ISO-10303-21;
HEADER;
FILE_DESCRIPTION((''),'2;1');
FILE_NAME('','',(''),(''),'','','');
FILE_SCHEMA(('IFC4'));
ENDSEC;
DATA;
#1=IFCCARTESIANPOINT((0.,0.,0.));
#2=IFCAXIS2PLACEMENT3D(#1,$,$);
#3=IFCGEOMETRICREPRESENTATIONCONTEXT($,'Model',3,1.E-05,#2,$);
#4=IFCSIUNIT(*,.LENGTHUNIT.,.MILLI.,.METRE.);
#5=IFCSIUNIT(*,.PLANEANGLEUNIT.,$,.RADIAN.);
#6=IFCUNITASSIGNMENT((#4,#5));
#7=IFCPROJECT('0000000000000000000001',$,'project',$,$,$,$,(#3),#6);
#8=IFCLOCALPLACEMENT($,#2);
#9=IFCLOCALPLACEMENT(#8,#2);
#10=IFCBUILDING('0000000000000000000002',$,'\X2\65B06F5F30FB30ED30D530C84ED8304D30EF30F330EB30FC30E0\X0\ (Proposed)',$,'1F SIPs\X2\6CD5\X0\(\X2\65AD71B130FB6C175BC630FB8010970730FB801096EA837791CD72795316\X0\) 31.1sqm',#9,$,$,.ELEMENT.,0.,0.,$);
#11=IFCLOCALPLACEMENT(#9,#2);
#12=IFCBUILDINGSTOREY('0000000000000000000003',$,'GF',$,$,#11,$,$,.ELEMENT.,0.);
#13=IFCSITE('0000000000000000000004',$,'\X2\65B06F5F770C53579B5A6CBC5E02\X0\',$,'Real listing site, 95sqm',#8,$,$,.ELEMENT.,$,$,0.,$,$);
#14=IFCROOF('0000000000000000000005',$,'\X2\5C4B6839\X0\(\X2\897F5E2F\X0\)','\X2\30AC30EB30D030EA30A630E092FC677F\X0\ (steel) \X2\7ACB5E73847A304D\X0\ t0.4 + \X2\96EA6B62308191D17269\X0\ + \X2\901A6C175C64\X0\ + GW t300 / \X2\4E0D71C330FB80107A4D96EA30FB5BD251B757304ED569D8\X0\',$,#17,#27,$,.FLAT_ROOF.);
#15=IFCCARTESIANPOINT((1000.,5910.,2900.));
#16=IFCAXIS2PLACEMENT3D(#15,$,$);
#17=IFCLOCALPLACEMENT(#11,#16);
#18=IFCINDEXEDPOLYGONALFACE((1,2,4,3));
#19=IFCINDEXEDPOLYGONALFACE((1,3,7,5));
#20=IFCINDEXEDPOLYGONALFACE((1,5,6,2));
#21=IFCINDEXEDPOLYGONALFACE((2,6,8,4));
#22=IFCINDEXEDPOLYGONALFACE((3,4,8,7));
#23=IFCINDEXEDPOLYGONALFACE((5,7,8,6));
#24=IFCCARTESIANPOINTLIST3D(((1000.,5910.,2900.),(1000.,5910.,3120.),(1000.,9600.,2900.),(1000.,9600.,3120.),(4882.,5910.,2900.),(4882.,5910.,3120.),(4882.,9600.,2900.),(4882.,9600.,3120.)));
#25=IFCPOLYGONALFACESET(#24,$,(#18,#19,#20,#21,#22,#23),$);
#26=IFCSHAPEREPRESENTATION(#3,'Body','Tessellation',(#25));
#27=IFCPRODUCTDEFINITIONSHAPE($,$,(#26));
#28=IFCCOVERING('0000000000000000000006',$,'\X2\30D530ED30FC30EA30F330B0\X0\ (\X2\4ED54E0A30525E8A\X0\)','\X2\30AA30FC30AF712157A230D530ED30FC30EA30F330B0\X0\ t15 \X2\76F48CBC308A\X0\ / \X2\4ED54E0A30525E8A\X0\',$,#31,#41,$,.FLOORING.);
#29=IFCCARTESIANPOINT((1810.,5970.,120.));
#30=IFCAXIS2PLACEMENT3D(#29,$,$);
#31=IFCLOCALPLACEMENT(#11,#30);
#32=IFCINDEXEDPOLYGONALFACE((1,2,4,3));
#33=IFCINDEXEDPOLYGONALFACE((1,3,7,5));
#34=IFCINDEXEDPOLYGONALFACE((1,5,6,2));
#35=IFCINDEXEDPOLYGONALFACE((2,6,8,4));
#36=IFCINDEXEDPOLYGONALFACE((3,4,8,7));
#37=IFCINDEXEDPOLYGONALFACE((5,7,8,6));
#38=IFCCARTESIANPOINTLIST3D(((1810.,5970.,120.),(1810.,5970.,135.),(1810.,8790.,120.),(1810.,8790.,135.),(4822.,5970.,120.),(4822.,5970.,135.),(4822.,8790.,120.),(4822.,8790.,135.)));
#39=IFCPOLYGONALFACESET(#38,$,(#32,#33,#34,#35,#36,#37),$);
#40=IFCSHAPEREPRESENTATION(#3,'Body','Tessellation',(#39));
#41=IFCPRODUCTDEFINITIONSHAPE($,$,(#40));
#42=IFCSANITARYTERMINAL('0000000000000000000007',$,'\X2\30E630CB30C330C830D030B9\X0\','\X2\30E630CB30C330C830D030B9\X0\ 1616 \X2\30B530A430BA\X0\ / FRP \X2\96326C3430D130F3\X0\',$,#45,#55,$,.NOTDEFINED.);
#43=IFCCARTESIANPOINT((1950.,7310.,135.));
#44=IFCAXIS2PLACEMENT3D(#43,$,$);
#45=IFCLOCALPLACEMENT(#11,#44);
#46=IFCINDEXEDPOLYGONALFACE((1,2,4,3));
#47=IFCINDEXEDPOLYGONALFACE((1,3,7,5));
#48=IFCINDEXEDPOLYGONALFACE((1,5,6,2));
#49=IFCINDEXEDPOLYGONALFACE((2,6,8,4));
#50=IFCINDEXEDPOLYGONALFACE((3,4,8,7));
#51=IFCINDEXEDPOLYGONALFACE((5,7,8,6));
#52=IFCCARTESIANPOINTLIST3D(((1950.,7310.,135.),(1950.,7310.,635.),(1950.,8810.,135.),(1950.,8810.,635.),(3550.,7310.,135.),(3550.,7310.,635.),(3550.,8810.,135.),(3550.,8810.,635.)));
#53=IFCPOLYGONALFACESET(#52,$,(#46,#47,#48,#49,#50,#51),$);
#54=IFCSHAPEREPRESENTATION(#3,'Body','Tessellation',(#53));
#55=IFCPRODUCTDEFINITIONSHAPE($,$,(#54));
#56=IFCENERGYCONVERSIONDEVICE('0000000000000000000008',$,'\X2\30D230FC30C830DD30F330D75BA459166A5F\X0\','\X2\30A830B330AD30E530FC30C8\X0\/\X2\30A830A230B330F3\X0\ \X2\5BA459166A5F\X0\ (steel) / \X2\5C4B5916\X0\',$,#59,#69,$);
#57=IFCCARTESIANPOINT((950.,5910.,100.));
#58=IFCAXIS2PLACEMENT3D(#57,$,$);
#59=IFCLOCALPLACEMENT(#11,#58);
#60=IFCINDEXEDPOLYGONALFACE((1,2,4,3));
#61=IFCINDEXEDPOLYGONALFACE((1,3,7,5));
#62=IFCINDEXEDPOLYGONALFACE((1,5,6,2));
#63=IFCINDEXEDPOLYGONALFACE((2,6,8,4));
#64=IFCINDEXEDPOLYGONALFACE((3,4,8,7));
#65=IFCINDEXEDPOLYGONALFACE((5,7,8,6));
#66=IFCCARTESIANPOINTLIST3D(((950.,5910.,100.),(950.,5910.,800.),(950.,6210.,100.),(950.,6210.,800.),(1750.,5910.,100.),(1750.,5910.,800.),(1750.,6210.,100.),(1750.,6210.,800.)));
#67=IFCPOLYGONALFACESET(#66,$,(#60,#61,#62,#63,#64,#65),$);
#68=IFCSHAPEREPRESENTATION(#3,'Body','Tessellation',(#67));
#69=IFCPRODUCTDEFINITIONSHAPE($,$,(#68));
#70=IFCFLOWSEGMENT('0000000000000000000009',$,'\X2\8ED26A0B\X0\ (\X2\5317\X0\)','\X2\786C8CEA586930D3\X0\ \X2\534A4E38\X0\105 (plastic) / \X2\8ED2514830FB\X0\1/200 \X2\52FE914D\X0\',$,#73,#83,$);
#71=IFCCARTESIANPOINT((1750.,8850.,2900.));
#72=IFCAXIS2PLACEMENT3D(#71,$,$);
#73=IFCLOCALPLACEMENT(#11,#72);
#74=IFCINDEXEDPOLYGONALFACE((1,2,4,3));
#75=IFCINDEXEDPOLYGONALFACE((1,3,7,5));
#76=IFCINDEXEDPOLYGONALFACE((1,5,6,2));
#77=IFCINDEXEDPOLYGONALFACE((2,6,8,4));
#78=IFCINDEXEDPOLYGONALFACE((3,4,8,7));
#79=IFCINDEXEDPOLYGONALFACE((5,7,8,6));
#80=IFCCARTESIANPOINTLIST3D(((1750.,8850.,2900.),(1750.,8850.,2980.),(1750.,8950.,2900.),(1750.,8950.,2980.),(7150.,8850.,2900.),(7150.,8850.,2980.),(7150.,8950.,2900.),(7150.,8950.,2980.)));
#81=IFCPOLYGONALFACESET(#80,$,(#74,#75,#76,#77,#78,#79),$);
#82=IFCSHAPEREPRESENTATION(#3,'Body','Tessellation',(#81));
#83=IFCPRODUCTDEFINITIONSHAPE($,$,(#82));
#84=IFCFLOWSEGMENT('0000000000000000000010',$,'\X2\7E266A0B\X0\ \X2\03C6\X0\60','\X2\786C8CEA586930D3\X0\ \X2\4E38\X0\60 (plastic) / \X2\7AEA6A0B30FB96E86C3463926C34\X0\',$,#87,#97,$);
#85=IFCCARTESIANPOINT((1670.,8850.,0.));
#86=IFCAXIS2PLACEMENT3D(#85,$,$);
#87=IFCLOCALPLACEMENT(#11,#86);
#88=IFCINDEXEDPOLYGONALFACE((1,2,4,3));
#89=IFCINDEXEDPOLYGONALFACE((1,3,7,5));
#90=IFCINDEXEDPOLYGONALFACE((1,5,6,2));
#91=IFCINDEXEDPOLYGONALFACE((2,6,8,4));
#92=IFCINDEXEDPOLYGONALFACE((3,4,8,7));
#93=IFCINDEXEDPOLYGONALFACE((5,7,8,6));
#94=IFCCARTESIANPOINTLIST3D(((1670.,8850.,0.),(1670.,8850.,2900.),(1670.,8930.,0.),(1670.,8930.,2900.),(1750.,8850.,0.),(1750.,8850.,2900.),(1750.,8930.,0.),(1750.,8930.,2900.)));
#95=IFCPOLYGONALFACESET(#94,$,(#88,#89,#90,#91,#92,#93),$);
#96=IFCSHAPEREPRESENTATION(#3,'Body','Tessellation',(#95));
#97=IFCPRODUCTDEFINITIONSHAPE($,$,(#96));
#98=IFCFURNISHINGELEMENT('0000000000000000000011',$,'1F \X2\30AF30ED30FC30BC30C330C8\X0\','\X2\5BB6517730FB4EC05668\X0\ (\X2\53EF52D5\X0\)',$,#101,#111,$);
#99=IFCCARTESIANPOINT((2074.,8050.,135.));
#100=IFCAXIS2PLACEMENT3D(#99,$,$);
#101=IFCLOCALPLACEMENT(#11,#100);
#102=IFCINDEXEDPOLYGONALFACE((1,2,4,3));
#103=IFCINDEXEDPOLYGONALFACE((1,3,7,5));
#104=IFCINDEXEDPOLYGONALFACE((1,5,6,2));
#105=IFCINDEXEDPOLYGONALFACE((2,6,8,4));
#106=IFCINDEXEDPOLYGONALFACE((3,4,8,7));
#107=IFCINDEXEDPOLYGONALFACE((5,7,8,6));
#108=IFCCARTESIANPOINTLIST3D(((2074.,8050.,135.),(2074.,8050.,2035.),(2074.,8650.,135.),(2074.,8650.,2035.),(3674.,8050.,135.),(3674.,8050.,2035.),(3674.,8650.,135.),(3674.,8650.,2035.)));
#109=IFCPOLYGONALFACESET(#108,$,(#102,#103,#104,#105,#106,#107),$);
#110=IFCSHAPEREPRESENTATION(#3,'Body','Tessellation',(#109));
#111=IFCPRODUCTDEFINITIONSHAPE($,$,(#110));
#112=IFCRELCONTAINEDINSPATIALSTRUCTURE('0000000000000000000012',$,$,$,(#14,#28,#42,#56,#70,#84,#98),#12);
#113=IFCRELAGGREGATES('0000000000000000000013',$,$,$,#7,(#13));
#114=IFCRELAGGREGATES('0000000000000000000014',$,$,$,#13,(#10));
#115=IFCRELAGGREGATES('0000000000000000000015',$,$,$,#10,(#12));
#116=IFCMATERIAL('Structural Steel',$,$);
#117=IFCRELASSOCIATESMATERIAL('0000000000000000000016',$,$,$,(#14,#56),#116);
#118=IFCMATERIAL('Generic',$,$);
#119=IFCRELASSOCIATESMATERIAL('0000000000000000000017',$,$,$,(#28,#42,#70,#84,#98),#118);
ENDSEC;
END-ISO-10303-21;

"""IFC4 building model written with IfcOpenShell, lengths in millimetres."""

from ifc_helpers import new_model, si_unit, frame, frame_2d, origin, place, context, project, spatial, rectangle, extrude, material, element, save


model = new_model("IFC4")

# Units and contexts
model_context = context("Model", 3, precision=1e-05, world=origin())
ifc_project = project(units=[si_unit("LENGTHUNIT", "METRE", prefix="MILLI"), si_unit("PLANEANGLEUNIT", "RADIAN")], contexts=[model_context])

# Site, building, storey
site_placement = place(None, origin())
site = spatial("IfcSite", under=ifc_project, at=site_placement, Name="新潟県南魚沼市", ObjectType="Real listing site, 95sqm", CompositionType="ELEMENT", RefElevation=0.0)
building_placement = place(site_placement, origin())
building = spatial("IfcBuilding", under=site, at=building_placement, Name="新潟・ロフト付きワンルーム (Proposed)", ObjectType="1F SIPs法(断熱・気密・耐震・耐雪荷重特化) 31.1sqm", CompositionType="ELEMENT", ElevationOfRefHeight=0.0, ElevationOfTerrain=0.0)
storey_placement = place(building_placement, origin())
storey = spatial("IfcBuildingStorey", under=building, at=storey_placement, Name="GF", CompositionType="ELEMENT", Elevation=0.0)

# Roof
ifc_material_1 = material(Name="Structural Steel")
roof_placement = place(storey_placement, frame((1000.0, 5910.0, 2900.0)))
element("IfcRoof", 1, at=roof_placement, inside=storey, material=ifc_material_1, Name="屋根(西帯)", Description="ガルバリウム鋼板 (steel) 立平葺き t0.4 + 雪止め金物 + 通気層 + GW t300 / 不燃・耐積雪・寒冷地仕様", PredefinedType="FLAT_ROOF", context=model_context, shape_type="SweptSolid", body=[
    extrude(rectangle(XDim=3882.0, YDim=3690.0, at=frame_2d((1941.0, 1845.0))), frame((1000.0, 5910.0, 2900.0)), (0.0, 0.0, 1.0), 220.0),
])

# Covering
ifc_material_2 = material(Name="Generic")
covering_placement = place(storey_placement, frame((1810.0, 5970.0, 120.0)))
element("IfcCovering", 2, at=covering_placement, inside=storey, material=ifc_material_2, Name="フローリング (仕上げ床)", Description="オーク無垢フローリング t15 直貼り / 仕上げ床", PredefinedType="FLOORING", context=model_context, shape_type="SweptSolid", body=[
    extrude(rectangle(XDim=3012.0, YDim=2820.0, at=frame_2d((1506.0, 1410.0))), frame((1810.0, 5970.0, 120.0)), (0.0, 0.0, 1.0), 15.0),
])

# Sanitary terminal
sanitary_terminal_placement = place(storey_placement, frame((1950.0, 7310.0, 135.0)))
element("IfcSanitaryTerminal", 3, at=sanitary_terminal_placement, inside=storey, material=ifc_material_2, Name="ユニットバス", Description="ユニットバス 1616 サイズ / FRP 防水パン", PredefinedType="NOTDEFINED", context=model_context, shape_type="SweptSolid", body=[
    extrude(rectangle(XDim=1600.0, YDim=1500.0, at=frame_2d((800.0, 750.0))), frame((1950.0, 7310.0, 135.0)), (0.0, 0.0, 1.0), 500.0),
])

# Energy conversion device
energy_conversion_device_placement = place(storey_placement, frame((950.0, 5910.0, 100.0)))
element("IfcEnergyConversionDevice", 4, at=energy_conversion_device_placement, inside=storey, material=ifc_material_1, Name="ヒートポンプ室外機", Description="エコキュート/エアコン 室外機 (steel) / 屋外", context=model_context, shape_type="SweptSolid", body=[
    extrude(rectangle(XDim=800.0, YDim=300.0, at=frame_2d((400.0, 150.0))), frame((950.0, 5910.0, 100.0)), (0.0, 0.0, 1.0), 700.0),
])

# Flow segments
flow_segment_1_placement = place(storey_placement, frame((1750.0, 8850.0, 2900.0)))
element("IfcFlowSegment", 5, at=flow_segment_1_placement, inside=storey, material=ifc_material_2, Name="軒樋 (北)", Description="硬質塩ビ 半丸105 (plastic) / 軒先・1/200 勾配", context=model_context, shape_type="SweptSolid", body=[
    extrude(rectangle(XDim=5400.0, YDim=100.0, at=frame_2d((2700.0, 50.0))), frame((1750.0, 8850.0, 2900.0)), (0.0, 0.0, 1.0), 80.0),
])
flow_segment_2_placement = place(storey_placement, frame((1670.0, 8850.0, 0.0)))
element("IfcFlowSegment", 6, at=flow_segment_2_placement, inside=storey, material=ifc_material_2, Name="縦樋 φ60", Description="硬質塩ビ 丸60 (plastic) / 竪樋・雨水排水", context=model_context, shape_type="SweptSolid", body=[
    extrude(rectangle(XDim=80.0, YDim=80.0, at=frame_2d((40.0, 40.0))), frame((1670.0, 8850.0, 0.0)), (0.0, 0.0, 1.0), 2900.0),
])

# Furnishing element
furnishing_placement = place(storey_placement, frame((2074.0, 8050.0, 135.0)))
element("IfcFurnishingElement", 7, at=furnishing_placement, inside=storey, material=ifc_material_2, Name="1F クローゼット", Description="家具・什器 (可動)", context=model_context, shape_type="SweptSolid", body=[
    extrude(rectangle(XDim=1600.0, YDim=600.0, at=frame_2d((800.0, 300.0))), frame((2074.0, 8050.0, 135.0)), (0.0, 0.0, 1.0), 1900.0),
])

save(model, "model.ifc")
